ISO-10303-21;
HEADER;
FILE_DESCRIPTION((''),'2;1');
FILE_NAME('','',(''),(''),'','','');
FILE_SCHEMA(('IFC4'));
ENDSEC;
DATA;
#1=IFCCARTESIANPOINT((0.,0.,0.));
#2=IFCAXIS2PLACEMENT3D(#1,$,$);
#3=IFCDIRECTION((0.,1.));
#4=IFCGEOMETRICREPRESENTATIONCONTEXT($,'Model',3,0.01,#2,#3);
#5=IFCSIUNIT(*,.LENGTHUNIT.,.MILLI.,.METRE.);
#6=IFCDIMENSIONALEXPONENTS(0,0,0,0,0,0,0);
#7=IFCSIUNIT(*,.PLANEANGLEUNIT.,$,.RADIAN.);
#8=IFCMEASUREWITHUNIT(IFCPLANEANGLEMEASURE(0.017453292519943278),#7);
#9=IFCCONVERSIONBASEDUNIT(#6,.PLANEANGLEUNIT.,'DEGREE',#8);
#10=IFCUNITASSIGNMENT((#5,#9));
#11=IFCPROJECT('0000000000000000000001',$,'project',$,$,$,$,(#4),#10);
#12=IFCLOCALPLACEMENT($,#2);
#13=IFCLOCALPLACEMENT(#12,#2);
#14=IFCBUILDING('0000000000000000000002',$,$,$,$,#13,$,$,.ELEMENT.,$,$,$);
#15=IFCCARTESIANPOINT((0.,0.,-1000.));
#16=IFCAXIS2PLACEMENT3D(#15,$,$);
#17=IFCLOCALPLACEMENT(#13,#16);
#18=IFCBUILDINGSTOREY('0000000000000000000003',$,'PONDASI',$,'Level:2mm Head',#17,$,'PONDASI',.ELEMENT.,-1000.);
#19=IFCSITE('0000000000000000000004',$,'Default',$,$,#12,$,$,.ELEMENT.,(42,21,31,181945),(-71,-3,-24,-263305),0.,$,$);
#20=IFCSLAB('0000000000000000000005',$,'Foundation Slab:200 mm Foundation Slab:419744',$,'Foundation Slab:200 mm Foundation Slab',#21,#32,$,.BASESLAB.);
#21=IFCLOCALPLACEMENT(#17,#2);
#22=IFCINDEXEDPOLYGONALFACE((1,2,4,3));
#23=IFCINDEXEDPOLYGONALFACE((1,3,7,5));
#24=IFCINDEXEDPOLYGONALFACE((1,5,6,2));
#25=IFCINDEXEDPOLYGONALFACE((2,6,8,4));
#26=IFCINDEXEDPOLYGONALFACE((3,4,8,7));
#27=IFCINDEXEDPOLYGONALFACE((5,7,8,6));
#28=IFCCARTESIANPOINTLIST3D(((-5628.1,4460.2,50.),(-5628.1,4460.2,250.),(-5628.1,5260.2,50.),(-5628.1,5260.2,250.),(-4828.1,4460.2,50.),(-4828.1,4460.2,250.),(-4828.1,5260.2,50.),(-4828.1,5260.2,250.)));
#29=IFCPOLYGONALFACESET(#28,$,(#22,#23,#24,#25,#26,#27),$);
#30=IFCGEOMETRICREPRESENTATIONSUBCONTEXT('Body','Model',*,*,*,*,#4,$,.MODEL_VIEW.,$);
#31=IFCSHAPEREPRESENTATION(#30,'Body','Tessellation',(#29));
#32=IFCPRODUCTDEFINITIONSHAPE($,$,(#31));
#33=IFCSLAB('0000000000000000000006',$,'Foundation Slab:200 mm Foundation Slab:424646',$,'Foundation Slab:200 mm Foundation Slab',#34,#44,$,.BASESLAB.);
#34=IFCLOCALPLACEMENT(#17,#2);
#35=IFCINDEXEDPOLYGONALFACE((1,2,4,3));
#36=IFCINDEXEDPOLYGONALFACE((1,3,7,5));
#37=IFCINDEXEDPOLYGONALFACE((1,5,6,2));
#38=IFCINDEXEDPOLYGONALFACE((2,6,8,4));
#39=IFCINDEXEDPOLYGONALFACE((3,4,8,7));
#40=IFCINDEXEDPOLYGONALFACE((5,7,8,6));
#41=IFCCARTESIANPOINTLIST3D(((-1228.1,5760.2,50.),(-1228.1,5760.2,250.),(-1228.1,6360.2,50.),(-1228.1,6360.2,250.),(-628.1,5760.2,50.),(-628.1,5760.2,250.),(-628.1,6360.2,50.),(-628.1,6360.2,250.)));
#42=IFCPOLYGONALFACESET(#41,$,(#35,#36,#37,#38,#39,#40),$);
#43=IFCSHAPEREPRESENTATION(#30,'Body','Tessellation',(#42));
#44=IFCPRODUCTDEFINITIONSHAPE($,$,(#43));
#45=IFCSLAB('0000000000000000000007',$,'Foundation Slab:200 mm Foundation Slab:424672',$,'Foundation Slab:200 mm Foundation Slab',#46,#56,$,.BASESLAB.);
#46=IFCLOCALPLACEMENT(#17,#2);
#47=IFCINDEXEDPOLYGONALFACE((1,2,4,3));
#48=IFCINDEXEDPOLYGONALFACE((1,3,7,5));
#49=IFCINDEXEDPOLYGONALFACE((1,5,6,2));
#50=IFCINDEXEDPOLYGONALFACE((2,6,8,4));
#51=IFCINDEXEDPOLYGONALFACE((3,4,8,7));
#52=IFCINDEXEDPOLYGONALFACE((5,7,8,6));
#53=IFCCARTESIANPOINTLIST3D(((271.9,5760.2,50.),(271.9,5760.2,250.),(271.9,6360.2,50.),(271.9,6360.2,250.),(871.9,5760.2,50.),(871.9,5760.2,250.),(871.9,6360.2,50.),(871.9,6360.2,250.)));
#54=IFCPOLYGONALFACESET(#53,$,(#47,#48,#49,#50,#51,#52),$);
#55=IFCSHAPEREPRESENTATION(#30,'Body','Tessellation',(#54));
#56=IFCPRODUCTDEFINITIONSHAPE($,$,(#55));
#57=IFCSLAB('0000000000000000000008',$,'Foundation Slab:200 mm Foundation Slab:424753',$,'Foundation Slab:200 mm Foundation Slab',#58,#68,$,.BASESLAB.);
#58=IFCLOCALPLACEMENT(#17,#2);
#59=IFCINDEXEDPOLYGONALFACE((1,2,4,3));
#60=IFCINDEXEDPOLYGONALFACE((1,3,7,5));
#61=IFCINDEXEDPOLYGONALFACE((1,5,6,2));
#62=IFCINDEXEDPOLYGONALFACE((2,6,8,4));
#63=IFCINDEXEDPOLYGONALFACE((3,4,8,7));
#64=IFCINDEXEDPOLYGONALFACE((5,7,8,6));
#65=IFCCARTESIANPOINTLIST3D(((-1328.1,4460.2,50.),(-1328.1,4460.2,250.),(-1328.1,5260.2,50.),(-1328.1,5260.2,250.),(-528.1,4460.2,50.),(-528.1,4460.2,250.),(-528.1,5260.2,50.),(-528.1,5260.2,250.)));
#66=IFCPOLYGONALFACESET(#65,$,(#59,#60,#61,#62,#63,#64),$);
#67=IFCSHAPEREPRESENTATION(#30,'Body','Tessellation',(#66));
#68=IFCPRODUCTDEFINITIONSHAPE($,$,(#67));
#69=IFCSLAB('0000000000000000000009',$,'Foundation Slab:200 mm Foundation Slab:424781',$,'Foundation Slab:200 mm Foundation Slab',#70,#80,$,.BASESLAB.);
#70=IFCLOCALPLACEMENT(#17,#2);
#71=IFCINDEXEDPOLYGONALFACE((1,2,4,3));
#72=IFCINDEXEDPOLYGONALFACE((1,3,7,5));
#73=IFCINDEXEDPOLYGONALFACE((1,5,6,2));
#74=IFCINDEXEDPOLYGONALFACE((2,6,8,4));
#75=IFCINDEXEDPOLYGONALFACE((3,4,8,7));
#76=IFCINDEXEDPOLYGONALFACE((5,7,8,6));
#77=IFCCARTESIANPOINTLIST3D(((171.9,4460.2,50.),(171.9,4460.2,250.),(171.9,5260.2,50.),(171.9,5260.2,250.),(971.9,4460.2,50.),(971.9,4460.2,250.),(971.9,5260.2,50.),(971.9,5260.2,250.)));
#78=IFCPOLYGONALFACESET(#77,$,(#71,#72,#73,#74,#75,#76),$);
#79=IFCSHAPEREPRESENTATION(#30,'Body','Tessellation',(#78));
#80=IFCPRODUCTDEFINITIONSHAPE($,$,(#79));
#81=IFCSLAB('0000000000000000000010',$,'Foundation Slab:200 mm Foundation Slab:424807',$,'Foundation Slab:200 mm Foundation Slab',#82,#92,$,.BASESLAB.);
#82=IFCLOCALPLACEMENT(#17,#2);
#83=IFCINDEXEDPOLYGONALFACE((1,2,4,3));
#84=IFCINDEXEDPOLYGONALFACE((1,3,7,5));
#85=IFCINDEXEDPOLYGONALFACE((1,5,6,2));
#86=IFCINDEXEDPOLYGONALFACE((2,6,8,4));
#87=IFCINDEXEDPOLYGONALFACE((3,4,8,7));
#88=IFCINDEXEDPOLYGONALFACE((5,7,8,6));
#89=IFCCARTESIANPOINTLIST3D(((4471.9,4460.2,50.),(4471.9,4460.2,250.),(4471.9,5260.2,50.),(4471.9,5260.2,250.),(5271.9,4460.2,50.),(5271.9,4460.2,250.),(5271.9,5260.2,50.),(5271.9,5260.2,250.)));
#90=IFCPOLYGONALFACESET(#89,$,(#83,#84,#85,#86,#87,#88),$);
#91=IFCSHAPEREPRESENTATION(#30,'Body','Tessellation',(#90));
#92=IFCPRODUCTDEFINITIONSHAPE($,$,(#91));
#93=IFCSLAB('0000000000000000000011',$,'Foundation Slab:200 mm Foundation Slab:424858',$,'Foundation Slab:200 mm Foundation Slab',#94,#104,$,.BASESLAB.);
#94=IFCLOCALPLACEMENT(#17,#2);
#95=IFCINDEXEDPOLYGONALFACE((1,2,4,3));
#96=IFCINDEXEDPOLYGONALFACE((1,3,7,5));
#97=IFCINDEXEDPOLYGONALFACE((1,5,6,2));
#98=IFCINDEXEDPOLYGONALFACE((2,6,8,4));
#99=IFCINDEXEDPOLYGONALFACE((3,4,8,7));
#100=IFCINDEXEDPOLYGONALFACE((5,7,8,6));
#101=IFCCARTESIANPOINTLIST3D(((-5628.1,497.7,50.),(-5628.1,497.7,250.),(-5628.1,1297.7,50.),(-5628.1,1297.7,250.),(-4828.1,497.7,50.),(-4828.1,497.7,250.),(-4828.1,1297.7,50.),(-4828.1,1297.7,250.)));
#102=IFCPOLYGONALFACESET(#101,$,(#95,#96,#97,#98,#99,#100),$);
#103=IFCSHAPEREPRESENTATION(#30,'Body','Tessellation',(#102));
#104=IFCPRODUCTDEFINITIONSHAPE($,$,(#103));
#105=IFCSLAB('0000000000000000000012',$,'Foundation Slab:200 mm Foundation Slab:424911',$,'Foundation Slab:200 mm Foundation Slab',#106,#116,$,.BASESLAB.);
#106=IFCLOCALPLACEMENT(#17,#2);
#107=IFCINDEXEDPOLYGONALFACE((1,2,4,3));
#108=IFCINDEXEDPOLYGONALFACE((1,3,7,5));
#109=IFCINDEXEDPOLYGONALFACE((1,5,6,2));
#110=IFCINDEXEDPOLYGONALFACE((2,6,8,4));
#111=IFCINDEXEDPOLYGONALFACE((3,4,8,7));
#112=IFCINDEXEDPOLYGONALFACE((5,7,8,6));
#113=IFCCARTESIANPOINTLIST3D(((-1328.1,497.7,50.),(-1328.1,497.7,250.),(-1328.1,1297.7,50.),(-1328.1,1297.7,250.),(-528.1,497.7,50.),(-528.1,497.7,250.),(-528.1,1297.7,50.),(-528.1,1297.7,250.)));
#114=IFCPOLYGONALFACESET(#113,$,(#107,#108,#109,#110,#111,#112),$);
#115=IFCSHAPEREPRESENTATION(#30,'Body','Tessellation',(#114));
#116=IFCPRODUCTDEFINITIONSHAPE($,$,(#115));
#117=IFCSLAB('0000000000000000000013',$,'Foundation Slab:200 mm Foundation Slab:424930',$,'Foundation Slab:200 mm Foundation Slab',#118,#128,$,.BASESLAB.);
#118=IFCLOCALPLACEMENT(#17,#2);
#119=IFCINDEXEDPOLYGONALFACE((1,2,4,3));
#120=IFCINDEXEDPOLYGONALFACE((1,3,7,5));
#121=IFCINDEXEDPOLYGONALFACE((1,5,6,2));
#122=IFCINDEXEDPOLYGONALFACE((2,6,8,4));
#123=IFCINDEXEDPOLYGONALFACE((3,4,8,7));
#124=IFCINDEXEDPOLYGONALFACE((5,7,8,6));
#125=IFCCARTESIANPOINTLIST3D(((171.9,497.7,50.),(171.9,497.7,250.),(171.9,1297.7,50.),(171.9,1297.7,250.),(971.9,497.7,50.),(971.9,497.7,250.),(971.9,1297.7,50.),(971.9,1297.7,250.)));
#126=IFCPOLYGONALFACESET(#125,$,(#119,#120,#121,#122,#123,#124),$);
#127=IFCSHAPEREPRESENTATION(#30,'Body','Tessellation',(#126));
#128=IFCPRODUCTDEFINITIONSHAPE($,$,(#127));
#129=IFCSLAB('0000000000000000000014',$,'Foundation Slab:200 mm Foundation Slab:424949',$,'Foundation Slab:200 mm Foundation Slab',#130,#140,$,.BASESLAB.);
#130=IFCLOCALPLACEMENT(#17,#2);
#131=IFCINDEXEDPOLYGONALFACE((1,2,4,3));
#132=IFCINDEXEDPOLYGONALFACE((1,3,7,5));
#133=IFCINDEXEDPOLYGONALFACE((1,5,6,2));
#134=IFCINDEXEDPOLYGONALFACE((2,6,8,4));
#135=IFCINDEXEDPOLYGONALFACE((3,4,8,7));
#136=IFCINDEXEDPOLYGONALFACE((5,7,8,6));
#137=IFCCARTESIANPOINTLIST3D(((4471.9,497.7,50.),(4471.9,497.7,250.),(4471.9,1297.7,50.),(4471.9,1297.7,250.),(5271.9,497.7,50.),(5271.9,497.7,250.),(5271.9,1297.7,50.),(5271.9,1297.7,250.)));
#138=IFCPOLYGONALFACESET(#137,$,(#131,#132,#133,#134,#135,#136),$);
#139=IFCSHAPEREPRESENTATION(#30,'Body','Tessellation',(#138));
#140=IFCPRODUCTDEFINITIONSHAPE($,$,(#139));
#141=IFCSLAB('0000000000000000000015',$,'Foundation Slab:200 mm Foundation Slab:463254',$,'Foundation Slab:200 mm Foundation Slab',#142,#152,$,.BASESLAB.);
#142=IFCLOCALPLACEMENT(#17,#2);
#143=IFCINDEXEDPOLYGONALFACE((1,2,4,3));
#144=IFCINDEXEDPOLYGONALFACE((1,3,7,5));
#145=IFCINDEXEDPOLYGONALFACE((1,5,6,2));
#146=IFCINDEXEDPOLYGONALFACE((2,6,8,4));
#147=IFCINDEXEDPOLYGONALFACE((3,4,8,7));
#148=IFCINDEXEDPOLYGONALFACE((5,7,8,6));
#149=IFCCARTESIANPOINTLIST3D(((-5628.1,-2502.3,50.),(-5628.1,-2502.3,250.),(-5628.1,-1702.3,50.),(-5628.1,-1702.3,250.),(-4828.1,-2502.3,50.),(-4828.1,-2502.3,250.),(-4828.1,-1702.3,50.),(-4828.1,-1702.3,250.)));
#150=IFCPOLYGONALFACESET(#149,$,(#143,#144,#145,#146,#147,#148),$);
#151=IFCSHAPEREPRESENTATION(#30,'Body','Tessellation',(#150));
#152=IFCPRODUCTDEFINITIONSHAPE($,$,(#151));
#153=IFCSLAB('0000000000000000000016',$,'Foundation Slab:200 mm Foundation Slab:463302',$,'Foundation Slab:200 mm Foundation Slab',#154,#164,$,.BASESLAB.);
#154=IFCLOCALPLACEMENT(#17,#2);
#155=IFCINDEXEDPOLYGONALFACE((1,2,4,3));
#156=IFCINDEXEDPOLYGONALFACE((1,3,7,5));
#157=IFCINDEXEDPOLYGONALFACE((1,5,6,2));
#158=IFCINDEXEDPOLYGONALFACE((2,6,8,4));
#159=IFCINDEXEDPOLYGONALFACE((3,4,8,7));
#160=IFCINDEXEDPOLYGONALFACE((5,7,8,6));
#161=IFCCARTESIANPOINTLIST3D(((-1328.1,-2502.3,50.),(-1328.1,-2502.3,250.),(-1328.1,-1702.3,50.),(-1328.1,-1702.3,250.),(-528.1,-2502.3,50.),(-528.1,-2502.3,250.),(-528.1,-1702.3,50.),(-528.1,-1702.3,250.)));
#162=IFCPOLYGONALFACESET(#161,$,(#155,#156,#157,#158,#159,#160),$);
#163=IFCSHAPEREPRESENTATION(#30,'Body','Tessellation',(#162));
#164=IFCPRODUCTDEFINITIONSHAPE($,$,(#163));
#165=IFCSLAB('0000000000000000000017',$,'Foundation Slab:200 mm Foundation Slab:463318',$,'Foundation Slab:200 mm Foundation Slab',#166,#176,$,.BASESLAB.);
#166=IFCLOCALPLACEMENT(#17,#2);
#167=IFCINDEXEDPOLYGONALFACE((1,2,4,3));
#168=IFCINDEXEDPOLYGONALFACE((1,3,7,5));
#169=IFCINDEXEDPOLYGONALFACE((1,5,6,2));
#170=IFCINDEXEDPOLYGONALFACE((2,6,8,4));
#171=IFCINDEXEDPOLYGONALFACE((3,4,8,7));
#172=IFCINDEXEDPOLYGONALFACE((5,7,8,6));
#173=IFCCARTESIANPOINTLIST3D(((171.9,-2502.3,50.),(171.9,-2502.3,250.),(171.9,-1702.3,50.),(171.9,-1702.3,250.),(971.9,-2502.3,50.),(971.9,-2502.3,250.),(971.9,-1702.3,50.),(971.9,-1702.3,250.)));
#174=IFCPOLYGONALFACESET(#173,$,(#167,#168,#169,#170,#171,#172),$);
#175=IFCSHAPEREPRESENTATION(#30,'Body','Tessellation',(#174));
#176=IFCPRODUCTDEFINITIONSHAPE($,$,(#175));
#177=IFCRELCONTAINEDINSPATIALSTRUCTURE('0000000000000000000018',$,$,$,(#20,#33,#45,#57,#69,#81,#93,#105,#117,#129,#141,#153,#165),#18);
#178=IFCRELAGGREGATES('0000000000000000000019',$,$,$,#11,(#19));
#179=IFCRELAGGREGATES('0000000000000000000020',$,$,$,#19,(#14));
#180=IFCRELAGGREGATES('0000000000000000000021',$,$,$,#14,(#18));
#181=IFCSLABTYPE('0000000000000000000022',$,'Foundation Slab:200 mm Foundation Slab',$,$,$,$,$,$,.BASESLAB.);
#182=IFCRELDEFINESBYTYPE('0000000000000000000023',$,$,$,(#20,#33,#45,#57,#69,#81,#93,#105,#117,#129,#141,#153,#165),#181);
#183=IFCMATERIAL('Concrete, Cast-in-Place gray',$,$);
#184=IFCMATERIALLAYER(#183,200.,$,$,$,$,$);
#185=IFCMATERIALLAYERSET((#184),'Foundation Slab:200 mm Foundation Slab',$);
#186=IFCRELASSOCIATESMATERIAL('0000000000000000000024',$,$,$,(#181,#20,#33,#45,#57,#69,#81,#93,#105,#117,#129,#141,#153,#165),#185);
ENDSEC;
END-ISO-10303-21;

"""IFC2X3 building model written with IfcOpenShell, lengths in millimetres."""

from ifc_helpers import new_model, entity, si_unit, converted_unit, direction, frame, origin, origin_2d_with_axis, place, context, subcontext, project, spatial, rectangle, extrude, material, layer, layer_set, layer_usage, type_object, element, save


model = new_model("IFC2X3")

# Units and contexts
model_context = context("Model", 3, precision=0.01, world=origin(), true_north=direction((0.0, 1.0)))
body_context = subcontext(model_context, "Body", "Model", "MODEL_VIEW")
ifc_project = project(units=[si_unit("LENGTHUNIT", "METRE", prefix="MILLI"), converted_unit("PLANEANGLEUNIT", "DEGREE", entity("IfcPlaneAngleMeasure", 0.017453292519943278), si_unit("PLANEANGLEUNIT", "RADIAN"), dimensions=[0, 0, 0, 0, 0, 0, 0])], contexts=[model_context])

# Site, building, storey
site_placement = place(None, origin())
site = spatial("IfcSite", under=ifc_project, at=site_placement, Name="Default", CompositionType="ELEMENT", RefLatitude=(42, 21, 31, 181945), RefLongitude=(-71, -3, -24, -263305), RefElevation=0.0)
building_placement = place(site_placement, origin())
building = spatial("IfcBuilding", under=site, at=building_placement, CompositionType="ELEMENT")
storey_placement = place(building_placement, frame((0.0, 0.0, -1000.0)))
storey = spatial("IfcBuildingStorey", under=building, at=storey_placement, Name="PONDASI", ObjectType="Level:2mm Head", LongName="PONDASI", CompositionType="ELEMENT", Elevation=-1000.0)

# Slabs
ifc_material_1 = material(Name="Concrete, Cast-in-Place gray")
ifc_layer_1 = layer(ifc_material_1, 200.0)
ifc_layer_set_1 = layer_set([ifc_layer_1], Name="Foundation Slab:200 mm Foundation Slab")
ifc_layer_usage_1 = layer_usage(ifc_layer_set_1, "AXIS3", "POSITIVE", 0.0)
slab_type_1 = type_object("IfcSlabType", Name="Foundation Slab:200 mm Foundation Slab", PredefinedType="BASESLAB", material=ifc_layer_set_1)
slab_1_placement = place(storey_placement, origin())
element("IfcSlab", 1, at=slab_1_placement, inside=storey, type_object=slab_type_1, material=ifc_layer_usage_1, Name="Foundation Slab:200 mm Foundation Slab:419744", ObjectType="Foundation Slab:200 mm Foundation Slab", PredefinedType="BASESLAB", context=body_context, shape_type="SweptSolid", body=[
    extrude(rectangle(XDim=800.0, YDim=800.0, at=origin_2d_with_axis()), frame((-5228.1, 4860.2, 250.0), z_axis=(0.0, 0.0, -1.0), x_axis=(0.0, 1.0, 0.0)), (0.0, 0.0, 1.0), 200.0),
])
ifc_layer_usage_2 = layer_usage(ifc_layer_set_1, "AXIS3", "POSITIVE", 0.0)
slab_2_placement = place(storey_placement, origin())
element("IfcSlab", 2, at=slab_2_placement, inside=storey, type_object=slab_type_1, material=ifc_layer_usage_2, Name="Foundation Slab:200 mm Foundation Slab:424646", ObjectType="Foundation Slab:200 mm Foundation Slab", PredefinedType="BASESLAB", context=body_context, shape_type="SweptSolid", body=[
    extrude(rectangle(XDim=600.0, YDim=600.0, at=origin_2d_with_axis()), frame((-928.1, 6060.2, 250.0), z_axis=(0.0, 0.0, -1.0), x_axis=(0.0, 1.0, 0.0)), (0.0, 0.0, 1.0), 200.0),
])
ifc_layer_usage_3 = layer_usage(ifc_layer_set_1, "AXIS3", "POSITIVE", 0.0)
slab_3_placement = place(storey_placement, origin())
element("IfcSlab", 3, at=slab_3_placement, inside=storey, type_object=slab_type_1, material=ifc_layer_usage_3, Name="Foundation Slab:200 mm Foundation Slab:424672", ObjectType="Foundation Slab:200 mm Foundation Slab", PredefinedType="BASESLAB", context=body_context, shape_type="SweptSolid", body=[
    extrude(rectangle(XDim=600.0, YDim=600.0, at=origin_2d_with_axis()), frame((571.9, 6060.2, 250.0), z_axis=(0.0, 0.0, -1.0), x_axis=(0.0, 1.0, 0.0)), (0.0, 0.0, 1.0), 200.0),
])
ifc_layer_usage_4 = layer_usage(ifc_layer_set_1, "AXIS3", "POSITIVE", 0.0)
slab_4_placement = place(storey_placement, origin())
element("IfcSlab", 4, at=slab_4_placement, inside=storey, type_object=slab_type_1, material=ifc_layer_usage_4, Name="Foundation Slab:200 mm Foundation Slab:424753", ObjectType="Foundation Slab:200 mm Foundation Slab", PredefinedType="BASESLAB", context=body_context, shape_type="SweptSolid", body=[
    extrude(rectangle(XDim=800.0, YDim=800.0, at=origin_2d_with_axis()), frame((-928.1, 4860.2, 250.0), z_axis=(0.0, 0.0, -1.0), x_axis=(0.0, 1.0, 0.0)), (0.0, 0.0, 1.0), 200.0),
])
ifc_layer_usage_5 = layer_usage(ifc_layer_set_1, "AXIS3", "POSITIVE", 0.0)
slab_5_placement = place(storey_placement, origin())
element("IfcSlab", 5, at=slab_5_placement, inside=storey, type_object=slab_type_1, material=ifc_layer_usage_5, Name="Foundation Slab:200 mm Foundation Slab:424781", ObjectType="Foundation Slab:200 mm Foundation Slab", PredefinedType="BASESLAB", context=body_context, shape_type="SweptSolid", body=[
    extrude(rectangle(XDim=800.0, YDim=800.0, at=origin_2d_with_axis()), frame((571.9, 4860.2, 250.0), z_axis=(0.0, 0.0, -1.0), x_axis=(0.0, 1.0, 0.0)), (0.0, 0.0, 1.0), 200.0),
])
ifc_layer_usage_6 = layer_usage(ifc_layer_set_1, "AXIS3", "POSITIVE", 0.0)
slab_6_placement = place(storey_placement, origin())
element("IfcSlab", 6, at=slab_6_placement, inside=storey, type_object=slab_type_1, material=ifc_layer_usage_6, Name="Foundation Slab:200 mm Foundation Slab:424807", ObjectType="Foundation Slab:200 mm Foundation Slab", PredefinedType="BASESLAB", context=body_context, shape_type="SweptSolid", body=[
    extrude(rectangle(XDim=800.0, YDim=800.0, at=origin_2d_with_axis()), frame((4871.9, 4860.2, 250.0), z_axis=(0.0, 0.0, -1.0), x_axis=(0.0, 1.0, 0.0)), (0.0, 0.0, 1.0), 200.0),
])
ifc_layer_usage_7 = layer_usage(ifc_layer_set_1, "AXIS3", "POSITIVE", 0.0)
slab_7_placement = place(storey_placement, origin())
element("IfcSlab", 7, at=slab_7_placement, inside=storey, type_object=slab_type_1, material=ifc_layer_usage_7, Name="Foundation Slab:200 mm Foundation Slab:424858", ObjectType="Foundation Slab:200 mm Foundation Slab", PredefinedType="BASESLAB", context=body_context, shape_type="SweptSolid", body=[
    extrude(rectangle(XDim=800.0, YDim=800.0, at=origin_2d_with_axis()), frame((-5228.1, 897.7, 250.0), z_axis=(0.0, 0.0, -1.0), x_axis=(0.0, 1.0, 0.0)), (0.0, 0.0, 1.0), 200.0),
])
ifc_layer_usage_8 = layer_usage(ifc_layer_set_1, "AXIS3", "POSITIVE", 0.0)
slab_8_placement = place(storey_placement, origin())
element("IfcSlab", 8, at=slab_8_placement, inside=storey, type_object=slab_type_1, material=ifc_layer_usage_8, Name="Foundation Slab:200 mm Foundation Slab:424911", ObjectType="Foundation Slab:200 mm Foundation Slab", PredefinedType="BASESLAB", context=body_context, shape_type="SweptSolid", body=[
    extrude(rectangle(XDim=800.0, YDim=800.0, at=origin_2d_with_axis()), frame((-928.1, 897.7, 250.0), z_axis=(0.0, 0.0, -1.0), x_axis=(0.0, 1.0, 0.0)), (0.0, 0.0, 1.0), 200.0),
])
ifc_layer_usage_9 = layer_usage(ifc_layer_set_1, "AXIS3", "POSITIVE", 0.0)
slab_9_placement = place(storey_placement, origin())
element("IfcSlab", 9, at=slab_9_placement, inside=storey, type_object=slab_type_1, material=ifc_layer_usage_9, Name="Foundation Slab:200 mm Foundation Slab:424930", ObjectType="Foundation Slab:200 mm Foundation Slab", PredefinedType="BASESLAB", context=body_context, shape_type="SweptSolid", body=[
    extrude(rectangle(XDim=800.0, YDim=800.0, at=origin_2d_with_axis()), frame((571.9, 897.7, 250.0), z_axis=(0.0, 0.0, -1.0), x_axis=(0.0, 1.0, 0.0)), (0.0, 0.0, 1.0), 200.0),
])
ifc_layer_usage_10 = layer_usage(ifc_layer_set_1, "AXIS3", "POSITIVE", 0.0)
slab_10_placement = place(storey_placement, origin())
element("IfcSlab", 10, at=slab_10_placement, inside=storey, type_object=slab_type_1, material=ifc_layer_usage_10, Name="Foundation Slab:200 mm Foundation Slab:424949", ObjectType="Foundation Slab:200 mm Foundation Slab", PredefinedType="BASESLAB", context=body_context, shape_type="SweptSolid", body=[
    extrude(rectangle(XDim=800.0, YDim=800.0, at=origin_2d_with_axis()), frame((4871.9, 897.7, 250.0), z_axis=(0.0, 0.0, -1.0), x_axis=(0.0, 1.0, 0.0)), (0.0, 0.0, 1.0), 200.0),
])
ifc_layer_usage_11 = layer_usage(ifc_layer_set_1, "AXIS3", "POSITIVE", 0.0)
slab_11_placement = place(storey_placement, origin())
element("IfcSlab", 11, at=slab_11_placement, inside=storey, type_object=slab_type_1, material=ifc_layer_usage_11, Name="Foundation Slab:200 mm Foundation Slab:463254", ObjectType="Foundation Slab:200 mm Foundation Slab", PredefinedType="BASESLAB", context=body_context, shape_type="SweptSolid", body=[
    extrude(rectangle(XDim=800.0, YDim=800.0, at=origin_2d_with_axis()), frame((-5228.1, -2102.3, 250.0), z_axis=(0.0, 0.0, -1.0), x_axis=(0.0, 1.0, 0.0)), (0.0, 0.0, 1.0), 200.0),
])
ifc_layer_usage_12 = layer_usage(ifc_layer_set_1, "AXIS3", "POSITIVE", 0.0)
slab_12_placement = place(storey_placement, origin())
element("IfcSlab", 12, at=slab_12_placement, inside=storey, type_object=slab_type_1, material=ifc_layer_usage_12, Name="Foundation Slab:200 mm Foundation Slab:463302", ObjectType="Foundation Slab:200 mm Foundation Slab", PredefinedType="BASESLAB", context=body_context, shape_type="SweptSolid", body=[
    extrude(rectangle(XDim=800.0, YDim=800.0, at=origin_2d_with_axis()), frame((-928.1, -2102.3, 250.0), z_axis=(0.0, 0.0, -1.0), x_axis=(0.0, 1.0, 0.0)), (0.0, 0.0, 1.0), 200.0),
])
ifc_layer_usage_13 = layer_usage(ifc_layer_set_1, "AXIS3", "POSITIVE", 0.0)
slab_13_placement = place(storey_placement, origin())
element("IfcSlab", 13, at=slab_13_placement, inside=storey, type_object=slab_type_1, material=ifc_layer_usage_13, Name="Foundation Slab:200 mm Foundation Slab:463318", ObjectType="Foundation Slab:200 mm Foundation Slab", PredefinedType="BASESLAB", context=body_context, shape_type="SweptSolid", body=[
    extrude(rectangle(XDim=800.0, YDim=800.0, at=origin_2d_with_axis()), frame((571.9, -2102.3, 250.0), z_axis=(0.0, 0.0, -1.0), x_axis=(0.0, 1.0, 0.0)), (0.0, 0.0, 1.0), 200.0),
])

save(model, "model.ifc")
